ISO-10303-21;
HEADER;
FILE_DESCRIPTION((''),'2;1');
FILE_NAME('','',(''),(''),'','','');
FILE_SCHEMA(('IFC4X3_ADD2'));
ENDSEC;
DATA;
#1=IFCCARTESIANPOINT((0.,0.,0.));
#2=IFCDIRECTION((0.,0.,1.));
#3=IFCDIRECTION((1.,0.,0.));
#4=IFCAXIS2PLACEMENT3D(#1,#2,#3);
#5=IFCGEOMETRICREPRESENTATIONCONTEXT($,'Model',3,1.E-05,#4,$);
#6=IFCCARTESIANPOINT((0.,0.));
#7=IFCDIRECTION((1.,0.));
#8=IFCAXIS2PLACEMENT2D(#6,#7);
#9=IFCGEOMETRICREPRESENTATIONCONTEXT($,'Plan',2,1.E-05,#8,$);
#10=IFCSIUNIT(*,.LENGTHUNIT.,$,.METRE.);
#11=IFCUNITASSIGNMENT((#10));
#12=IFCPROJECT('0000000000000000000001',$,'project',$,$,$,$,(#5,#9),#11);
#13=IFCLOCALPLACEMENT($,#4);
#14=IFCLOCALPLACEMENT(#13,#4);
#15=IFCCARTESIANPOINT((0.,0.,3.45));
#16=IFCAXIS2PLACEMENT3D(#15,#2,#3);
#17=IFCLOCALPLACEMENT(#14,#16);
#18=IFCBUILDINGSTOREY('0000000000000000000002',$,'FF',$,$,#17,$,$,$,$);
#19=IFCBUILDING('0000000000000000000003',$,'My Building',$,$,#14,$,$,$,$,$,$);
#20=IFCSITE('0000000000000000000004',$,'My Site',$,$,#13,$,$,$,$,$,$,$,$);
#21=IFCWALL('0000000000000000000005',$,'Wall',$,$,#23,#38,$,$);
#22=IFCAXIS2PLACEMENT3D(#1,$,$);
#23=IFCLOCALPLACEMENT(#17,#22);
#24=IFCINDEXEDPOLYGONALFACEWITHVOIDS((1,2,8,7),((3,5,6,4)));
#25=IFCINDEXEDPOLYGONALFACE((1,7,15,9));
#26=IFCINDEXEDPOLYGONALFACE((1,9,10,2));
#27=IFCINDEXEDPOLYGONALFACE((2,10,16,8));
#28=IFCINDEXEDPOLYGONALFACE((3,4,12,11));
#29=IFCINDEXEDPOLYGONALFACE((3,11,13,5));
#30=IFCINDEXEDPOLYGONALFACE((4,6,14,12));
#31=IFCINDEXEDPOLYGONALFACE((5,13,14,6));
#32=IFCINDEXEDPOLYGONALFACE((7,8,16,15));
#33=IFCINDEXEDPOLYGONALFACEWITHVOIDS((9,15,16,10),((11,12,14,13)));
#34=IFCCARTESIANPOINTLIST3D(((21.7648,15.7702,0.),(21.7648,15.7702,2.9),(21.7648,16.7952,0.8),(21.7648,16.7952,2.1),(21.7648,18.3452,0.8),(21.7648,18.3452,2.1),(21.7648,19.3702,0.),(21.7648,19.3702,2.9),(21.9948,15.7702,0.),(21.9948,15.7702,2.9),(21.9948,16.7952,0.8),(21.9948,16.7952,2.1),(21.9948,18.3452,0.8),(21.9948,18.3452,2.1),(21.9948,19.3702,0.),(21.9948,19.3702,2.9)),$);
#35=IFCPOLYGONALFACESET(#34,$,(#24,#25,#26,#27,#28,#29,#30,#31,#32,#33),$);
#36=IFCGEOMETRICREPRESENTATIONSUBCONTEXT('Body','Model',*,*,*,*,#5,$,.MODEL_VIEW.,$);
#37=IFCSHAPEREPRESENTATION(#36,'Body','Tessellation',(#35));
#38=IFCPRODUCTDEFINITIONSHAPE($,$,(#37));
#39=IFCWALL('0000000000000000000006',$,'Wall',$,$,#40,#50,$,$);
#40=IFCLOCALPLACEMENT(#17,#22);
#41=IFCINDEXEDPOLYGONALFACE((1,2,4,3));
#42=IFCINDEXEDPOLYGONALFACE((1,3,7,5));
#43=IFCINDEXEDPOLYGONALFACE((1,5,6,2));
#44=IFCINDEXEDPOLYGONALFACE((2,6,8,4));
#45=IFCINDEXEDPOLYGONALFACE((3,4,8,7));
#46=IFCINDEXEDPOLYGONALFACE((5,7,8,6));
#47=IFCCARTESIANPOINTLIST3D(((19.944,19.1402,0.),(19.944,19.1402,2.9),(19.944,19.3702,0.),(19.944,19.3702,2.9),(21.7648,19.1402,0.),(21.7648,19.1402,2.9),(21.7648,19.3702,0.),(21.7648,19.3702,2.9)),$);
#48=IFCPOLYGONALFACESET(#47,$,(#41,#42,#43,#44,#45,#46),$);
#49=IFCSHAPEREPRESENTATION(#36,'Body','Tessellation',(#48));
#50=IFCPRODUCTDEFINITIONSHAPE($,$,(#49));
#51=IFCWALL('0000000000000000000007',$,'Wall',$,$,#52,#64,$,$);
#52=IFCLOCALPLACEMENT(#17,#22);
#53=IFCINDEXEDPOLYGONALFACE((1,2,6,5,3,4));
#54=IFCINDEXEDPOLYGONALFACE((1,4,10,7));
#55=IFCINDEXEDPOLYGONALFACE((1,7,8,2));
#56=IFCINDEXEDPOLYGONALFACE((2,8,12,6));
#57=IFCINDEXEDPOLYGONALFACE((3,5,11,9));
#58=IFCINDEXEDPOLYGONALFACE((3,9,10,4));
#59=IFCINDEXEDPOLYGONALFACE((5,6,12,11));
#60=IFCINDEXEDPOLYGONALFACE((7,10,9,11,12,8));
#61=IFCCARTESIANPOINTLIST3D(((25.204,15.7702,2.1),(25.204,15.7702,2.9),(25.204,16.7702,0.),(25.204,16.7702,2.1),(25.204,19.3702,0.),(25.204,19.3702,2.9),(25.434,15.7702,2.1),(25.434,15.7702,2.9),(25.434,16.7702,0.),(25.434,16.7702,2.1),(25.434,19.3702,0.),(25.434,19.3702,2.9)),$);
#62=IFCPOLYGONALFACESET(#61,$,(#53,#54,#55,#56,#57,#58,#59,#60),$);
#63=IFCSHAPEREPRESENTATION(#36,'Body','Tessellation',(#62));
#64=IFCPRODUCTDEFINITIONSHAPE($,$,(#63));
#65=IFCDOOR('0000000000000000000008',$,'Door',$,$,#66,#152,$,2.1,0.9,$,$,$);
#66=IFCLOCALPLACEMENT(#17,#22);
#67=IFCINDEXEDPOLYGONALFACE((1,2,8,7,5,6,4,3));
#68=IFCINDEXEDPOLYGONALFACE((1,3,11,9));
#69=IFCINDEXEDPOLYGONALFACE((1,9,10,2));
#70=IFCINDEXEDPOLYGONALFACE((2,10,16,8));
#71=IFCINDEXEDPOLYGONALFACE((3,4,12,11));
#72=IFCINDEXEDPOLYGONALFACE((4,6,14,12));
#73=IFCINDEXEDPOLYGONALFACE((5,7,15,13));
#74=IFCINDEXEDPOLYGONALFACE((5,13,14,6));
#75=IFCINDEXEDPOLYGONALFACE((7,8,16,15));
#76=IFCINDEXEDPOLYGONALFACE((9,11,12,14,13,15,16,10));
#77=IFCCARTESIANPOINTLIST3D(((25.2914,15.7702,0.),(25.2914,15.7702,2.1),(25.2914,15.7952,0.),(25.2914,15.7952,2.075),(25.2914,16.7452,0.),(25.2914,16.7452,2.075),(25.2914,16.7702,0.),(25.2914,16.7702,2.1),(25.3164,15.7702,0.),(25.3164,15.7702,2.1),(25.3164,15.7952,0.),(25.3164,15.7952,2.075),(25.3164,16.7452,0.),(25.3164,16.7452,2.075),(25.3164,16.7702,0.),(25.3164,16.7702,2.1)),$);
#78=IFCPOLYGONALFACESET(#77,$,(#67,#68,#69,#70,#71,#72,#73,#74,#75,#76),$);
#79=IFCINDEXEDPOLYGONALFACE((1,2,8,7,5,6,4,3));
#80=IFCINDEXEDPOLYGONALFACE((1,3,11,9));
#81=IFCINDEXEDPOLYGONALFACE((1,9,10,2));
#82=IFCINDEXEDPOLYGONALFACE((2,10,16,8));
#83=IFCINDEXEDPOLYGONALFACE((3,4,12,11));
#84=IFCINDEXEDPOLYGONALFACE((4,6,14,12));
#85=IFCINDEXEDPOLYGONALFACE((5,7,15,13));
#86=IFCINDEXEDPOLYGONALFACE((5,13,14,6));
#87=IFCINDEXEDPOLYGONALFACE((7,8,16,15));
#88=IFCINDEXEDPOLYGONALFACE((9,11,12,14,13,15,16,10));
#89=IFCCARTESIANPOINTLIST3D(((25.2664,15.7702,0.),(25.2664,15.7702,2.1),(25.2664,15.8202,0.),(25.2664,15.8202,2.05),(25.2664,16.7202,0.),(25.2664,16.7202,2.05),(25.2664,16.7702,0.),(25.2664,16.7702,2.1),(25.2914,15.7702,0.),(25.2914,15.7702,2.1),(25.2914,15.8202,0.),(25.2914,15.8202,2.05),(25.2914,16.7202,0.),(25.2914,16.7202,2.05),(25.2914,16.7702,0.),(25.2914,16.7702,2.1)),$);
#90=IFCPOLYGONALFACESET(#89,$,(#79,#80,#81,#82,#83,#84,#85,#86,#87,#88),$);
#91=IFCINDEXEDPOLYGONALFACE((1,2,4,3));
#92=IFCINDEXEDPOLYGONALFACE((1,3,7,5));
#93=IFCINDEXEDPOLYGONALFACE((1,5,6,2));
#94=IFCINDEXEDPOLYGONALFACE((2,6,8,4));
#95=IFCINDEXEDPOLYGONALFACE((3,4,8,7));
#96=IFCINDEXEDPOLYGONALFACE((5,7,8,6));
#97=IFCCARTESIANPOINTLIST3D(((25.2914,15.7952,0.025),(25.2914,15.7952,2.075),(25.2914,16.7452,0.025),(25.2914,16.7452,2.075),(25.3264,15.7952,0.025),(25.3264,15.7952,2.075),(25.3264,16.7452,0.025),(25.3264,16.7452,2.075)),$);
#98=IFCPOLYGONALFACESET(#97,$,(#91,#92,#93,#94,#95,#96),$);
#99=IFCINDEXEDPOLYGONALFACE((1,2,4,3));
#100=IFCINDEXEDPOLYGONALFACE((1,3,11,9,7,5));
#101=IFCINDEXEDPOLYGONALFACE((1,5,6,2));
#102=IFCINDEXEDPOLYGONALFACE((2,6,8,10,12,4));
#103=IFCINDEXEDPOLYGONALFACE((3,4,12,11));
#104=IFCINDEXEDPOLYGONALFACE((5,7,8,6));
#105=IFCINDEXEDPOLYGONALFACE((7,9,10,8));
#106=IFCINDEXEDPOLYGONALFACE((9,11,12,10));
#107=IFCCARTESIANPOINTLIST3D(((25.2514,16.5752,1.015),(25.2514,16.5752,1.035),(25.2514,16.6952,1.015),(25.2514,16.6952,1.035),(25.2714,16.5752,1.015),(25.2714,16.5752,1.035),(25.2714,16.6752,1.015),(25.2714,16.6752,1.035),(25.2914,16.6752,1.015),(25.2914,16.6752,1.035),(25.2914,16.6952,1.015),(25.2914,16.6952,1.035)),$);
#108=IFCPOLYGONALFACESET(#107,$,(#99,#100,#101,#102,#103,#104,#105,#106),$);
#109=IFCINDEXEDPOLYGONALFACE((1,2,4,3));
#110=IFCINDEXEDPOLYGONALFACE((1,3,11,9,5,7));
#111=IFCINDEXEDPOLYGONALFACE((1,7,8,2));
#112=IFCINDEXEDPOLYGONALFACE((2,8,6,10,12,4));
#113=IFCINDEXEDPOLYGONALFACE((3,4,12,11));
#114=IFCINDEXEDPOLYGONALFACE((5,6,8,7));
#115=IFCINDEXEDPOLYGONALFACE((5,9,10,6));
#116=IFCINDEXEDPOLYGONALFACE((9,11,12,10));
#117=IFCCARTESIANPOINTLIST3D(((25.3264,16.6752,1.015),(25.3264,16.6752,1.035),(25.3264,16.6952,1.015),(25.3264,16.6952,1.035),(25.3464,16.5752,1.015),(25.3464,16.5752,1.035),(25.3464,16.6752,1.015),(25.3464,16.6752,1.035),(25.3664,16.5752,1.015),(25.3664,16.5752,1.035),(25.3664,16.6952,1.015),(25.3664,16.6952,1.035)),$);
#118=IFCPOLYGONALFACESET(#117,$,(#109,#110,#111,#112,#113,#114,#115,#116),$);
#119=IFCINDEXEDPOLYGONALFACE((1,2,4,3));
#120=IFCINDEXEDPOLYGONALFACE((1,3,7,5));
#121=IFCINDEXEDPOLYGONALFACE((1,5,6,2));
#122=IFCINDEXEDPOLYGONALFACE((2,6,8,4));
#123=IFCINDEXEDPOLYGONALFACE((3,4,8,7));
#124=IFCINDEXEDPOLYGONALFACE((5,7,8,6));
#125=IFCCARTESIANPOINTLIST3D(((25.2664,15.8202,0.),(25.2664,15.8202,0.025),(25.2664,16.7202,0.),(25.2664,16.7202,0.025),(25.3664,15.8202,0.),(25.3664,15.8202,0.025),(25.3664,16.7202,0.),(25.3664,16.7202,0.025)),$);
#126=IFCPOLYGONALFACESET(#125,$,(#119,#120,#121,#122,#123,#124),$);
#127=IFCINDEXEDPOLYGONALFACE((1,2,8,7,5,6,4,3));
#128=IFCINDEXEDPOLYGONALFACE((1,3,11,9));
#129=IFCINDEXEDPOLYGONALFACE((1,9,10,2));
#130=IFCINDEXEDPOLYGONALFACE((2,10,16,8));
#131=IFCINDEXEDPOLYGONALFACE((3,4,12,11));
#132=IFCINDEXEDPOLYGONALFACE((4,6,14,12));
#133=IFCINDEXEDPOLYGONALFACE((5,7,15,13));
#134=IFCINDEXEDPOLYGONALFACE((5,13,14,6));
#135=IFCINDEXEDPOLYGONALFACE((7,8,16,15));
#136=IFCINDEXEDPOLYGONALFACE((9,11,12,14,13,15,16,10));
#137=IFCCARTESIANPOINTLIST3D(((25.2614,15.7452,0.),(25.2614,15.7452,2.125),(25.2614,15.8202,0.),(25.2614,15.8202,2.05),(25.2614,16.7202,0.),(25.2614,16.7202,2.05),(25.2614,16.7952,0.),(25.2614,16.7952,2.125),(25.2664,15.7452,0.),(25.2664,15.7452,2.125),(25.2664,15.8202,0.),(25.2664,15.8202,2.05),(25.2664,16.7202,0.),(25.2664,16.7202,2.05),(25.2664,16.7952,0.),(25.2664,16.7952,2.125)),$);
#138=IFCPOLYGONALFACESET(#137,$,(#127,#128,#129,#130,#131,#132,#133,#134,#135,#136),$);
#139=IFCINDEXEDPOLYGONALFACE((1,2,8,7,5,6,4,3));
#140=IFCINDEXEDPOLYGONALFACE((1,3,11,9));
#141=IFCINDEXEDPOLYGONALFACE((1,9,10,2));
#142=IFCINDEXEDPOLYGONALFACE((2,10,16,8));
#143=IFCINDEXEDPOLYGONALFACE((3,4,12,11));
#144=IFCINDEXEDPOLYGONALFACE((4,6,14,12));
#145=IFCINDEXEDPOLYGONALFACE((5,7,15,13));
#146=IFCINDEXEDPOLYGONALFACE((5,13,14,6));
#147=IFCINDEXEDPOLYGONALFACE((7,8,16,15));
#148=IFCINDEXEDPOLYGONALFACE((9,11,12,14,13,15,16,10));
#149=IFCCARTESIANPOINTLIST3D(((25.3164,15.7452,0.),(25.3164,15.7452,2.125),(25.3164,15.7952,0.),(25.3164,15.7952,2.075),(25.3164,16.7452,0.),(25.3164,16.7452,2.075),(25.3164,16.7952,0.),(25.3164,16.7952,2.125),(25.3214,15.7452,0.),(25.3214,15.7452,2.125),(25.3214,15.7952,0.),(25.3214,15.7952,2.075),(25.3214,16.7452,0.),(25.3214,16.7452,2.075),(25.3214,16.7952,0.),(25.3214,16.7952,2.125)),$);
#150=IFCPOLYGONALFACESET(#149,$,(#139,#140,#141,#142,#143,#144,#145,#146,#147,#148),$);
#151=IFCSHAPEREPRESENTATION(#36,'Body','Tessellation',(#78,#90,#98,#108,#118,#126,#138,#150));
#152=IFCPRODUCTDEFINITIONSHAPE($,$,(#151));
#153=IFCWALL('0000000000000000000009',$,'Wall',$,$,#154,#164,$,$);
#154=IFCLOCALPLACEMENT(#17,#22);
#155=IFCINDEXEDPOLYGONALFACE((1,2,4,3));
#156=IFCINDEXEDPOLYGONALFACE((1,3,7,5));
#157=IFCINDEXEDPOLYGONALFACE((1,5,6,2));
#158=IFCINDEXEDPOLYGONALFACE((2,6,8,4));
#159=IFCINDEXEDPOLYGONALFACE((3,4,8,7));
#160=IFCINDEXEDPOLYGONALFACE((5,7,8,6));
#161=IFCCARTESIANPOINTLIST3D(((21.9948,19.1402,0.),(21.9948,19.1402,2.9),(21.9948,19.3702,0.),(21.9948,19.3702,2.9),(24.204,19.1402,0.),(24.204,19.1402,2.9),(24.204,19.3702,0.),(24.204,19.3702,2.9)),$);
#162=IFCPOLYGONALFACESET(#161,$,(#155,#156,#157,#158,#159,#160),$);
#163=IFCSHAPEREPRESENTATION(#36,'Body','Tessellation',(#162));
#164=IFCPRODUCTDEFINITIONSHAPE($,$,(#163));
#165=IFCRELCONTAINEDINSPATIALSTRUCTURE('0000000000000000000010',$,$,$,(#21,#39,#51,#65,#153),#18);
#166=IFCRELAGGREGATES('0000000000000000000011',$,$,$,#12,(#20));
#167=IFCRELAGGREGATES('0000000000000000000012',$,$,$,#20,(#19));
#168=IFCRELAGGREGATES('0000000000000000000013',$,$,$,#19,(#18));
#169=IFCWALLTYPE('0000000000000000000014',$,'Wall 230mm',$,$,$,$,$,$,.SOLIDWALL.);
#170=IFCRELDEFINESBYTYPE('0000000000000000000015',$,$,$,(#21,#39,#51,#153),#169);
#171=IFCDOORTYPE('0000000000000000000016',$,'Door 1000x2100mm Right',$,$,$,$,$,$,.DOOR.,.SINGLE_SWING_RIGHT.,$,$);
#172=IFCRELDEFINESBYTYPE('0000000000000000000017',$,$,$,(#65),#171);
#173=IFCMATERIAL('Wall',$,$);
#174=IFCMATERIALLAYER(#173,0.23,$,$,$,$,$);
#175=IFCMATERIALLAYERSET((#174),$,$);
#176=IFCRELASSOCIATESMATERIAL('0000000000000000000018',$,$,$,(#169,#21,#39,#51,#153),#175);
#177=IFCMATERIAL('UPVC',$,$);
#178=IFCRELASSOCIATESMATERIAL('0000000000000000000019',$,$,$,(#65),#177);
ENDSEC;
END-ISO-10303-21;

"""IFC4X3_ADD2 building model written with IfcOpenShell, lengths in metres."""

from ifc_helpers import new_model, entity, si_unit, frame, origin_with_axes, origin_2d_with_axis, place, context, subcontext, project, spatial, line, indexed_curve, outline, extrude, shape, source, transform, mapped, material, layer, layer_set, layer_usage, type_object, type_shapes, element, fill, save


model = new_model("IFC4X3_ADD2")

# Units and contexts
model_context = context("Model", 3, precision=1e-05, world=origin_with_axes())
plan_context = context("Plan", 2, precision=1e-05, world=origin_2d_with_axis())
body_context_1 = subcontext(model_context, "Body", "Model", "MODEL_VIEW")
body_context_2 = subcontext(plan_context, "Body", "Plan", "PLAN_VIEW")
ifc_project = project(units=[si_unit("LENGTHUNIT", "METRE")], contexts=[model_context, plan_context])

# Site, building, storey
site_placement = place(None, origin_with_axes())
site = spatial("IfcSite", under=ifc_project, at=site_placement, Name="My Site")
building_placement = place(site_placement, origin_with_axes())
building = spatial("IfcBuilding", under=site, at=building_placement, Name="My Building")
storey_placement = place(building_placement, frame((0.0, 0.0, 3.45), z_axis=(0.0, 0.0, 1.0), x_axis=(1.0, 0.0, 0.0)))
storey = spatial("IfcBuildingStorey", under=building, at=storey_placement, Name="FF")

# Shared definitions
ifc_material_1 = material(Name="Wall")
ifc_material_2 = material(Name="UPVC")

# Shared definitions
ifc_layer_1 = layer(ifc_material_1, 0.23)
ifc_layer_set_1 = layer_set([ifc_layer_1])
wall_type_1 = type_object("IfcWallType", Name="Wall 230mm", PredefinedType="SOLIDWALL", material=ifc_layer_set_1)

# Wall, opening
ifc_layer_usage_1 = layer_usage(ifc_layer_set_1, "AXIS2", "POSITIVE", 0.0)
wall_1_placement = place(storey_placement, frame((21.9948, 15.7702, 0.0), z_axis=(0.0, 0.0, 1.0), x_axis=(0.000001, 1.0, 0.0)))
wall_1 = element("IfcWall", 1, at=wall_1_placement, inside=storey, type_object=wall_type_1, material=ifc_layer_usage_1, Name="Wall", context=body_context_1, shape_type="SweptSolid", body=[
    extrude(outline(indexed_curve([(0.0, 0.0), (0.0, 0.23), (3.6, 0.23), (3.6, 0.0), (0.0, 0.0)], self_intersect=False)), origin_with_axes(), (0.0, 0.0, 1.0), 2.9),
])
shared_shape_1 = source(origin_with_axes(), body_context_1, "Body", "SweptSolid", [
    extrude(outline(indexed_curve([(0.0, 0.0), (1.55, 0.0), (1.55, 1.3), (0.0, 1.3)], segments=[line(1, 2, 3, 4, 1)])), frame((-0.775, -0.6, 0.0), z_axis=(0.0, -1.0, 0.0), x_axis=(1.0, 0.0, 0.0)), (0.0, 0.0, -1.0), 1.2),
])
opening_1_placement = place(wall_1_placement, frame((1.8, 0.0, 0.8), z_axis=(0.0, 0.0, 1.0), x_axis=(1.0, 0.0, 0.0)))
element("IfcOpeningElement", 2, at=opening_1_placement, cuts=wall_1, PredefinedType="OPENING", context=body_context_1, shape_type="MappedRepresentation", body=[
    mapped(shared_shape_1, transform((0.0, 0.0, 0.0), x_axis=(1.0, 0.0, 0.0), y_axis=(0.0, 1.0, 0.0), z_axis=(0.0, 0.0, 1.0), scale=1.0)),
])

# Wall
ifc_layer_usage_2 = layer_usage(ifc_layer_set_1, "AXIS2", "POSITIVE", 0.0)
wall_2_placement = place(storey_placement, frame((21.7648, 19.3702, 0.0), z_axis=(0.0, 0.0, 1.0), x_axis=(-1.0, 0.0, 0.0)))
element("IfcWall", 3, at=wall_2_placement, inside=storey, type_object=wall_type_1, material=ifc_layer_usage_2, Name="Wall", context=body_context_1, shape_type="SweptSolid", body=[
    extrude(outline(indexed_curve([(0.0, 0.0), (0.0, 0.23), (1.8208, 0.23), (1.8208, 0.0), (0.0, 0.0)], self_intersect=False)), origin_with_axes(), (0.0, 0.0, 1.0), 2.9),
])

# Wall, opening, door
ifc_layer_usage_3 = layer_usage(ifc_layer_set_1, "AXIS2", "POSITIVE", 0.0)
wall_3_placement = place(storey_placement, frame((25.434, 15.7702, 0.0), z_axis=(0.0, 0.0, 1.0), x_axis=(0.000001, 1.0, 0.0)))
wall_3 = element("IfcWall", 4, at=wall_3_placement, inside=storey, type_object=wall_type_1, material=ifc_layer_usage_3, Name="Wall", context=body_context_1, shape_type="SweptSolid", body=[
    extrude(outline(indexed_curve([(0.0, 0.0), (0.0, 0.23), (3.6, 0.23), (3.6, 0.0), (0.0, 0.0)], self_intersect=False)), origin_with_axes(), (0.0, 0.0, 1.0), 2.9),
])
shared_shape_2 = source(origin_with_axes(), body_context_1, "Body", "SweptSolid", [
    extrude(outline(indexed_curve([(0.0, 0.0), (1.0, 0.0), (1.0, 2.1), (0.0, 2.1)], segments=[line(1, 2, 3, 4, 1)])), frame((0.0, -0.6, 0.0), z_axis=(0.0, -1.0, 0.0), x_axis=(1.0, 0.0, 0.0)), (0.0, 0.0, -1.0), 1.2),
])
opening_2_placement = place(wall_3_placement, frame((1.0, 0.1676, 0.0), z_axis=(0.0, 0.0, 1.0), x_axis=(-1.0, 0.0, 0.0)))
opening_2 = element("IfcOpeningElement", 5, at=opening_2_placement, cuts=wall_3, PredefinedType="OPENING", context=body_context_1, shape_type="MappedRepresentation", body=[
    mapped(shared_shape_2, transform((0.0, 0.0, 0.0), x_axis=(1.0, 0.0, 0.0), y_axis=(0.0, 1.0, 0.0), z_axis=(0.0, 0.0, 1.0), scale=1.0)),
])
door_type_1 = type_object("IfcDoorType", Name="Door 1000x2100mm Right", OperationType="SINGLE_SWING_RIGHT", PredefinedType="DOOR")
shared_shape_3 = source(origin_with_axes(), body_context_1, "Body", "SweptSolid", [
    extrude(outline(indexed_curve([(0.0, 0.0), (0.0, 2.1), (1.0, 2.1), (1.0, 0.0), (0.975, 0.0), (0.975, 2.075), (0.025, 2.075), (0.025, 0.0)], segments=[line(1, 2, 3, 4, 5, 6, 7, 8, 1)])), frame((0.0, 0.025, 0.0), z_axis=(0.0, -1.0, 0.0), x_axis=(1.0, 0.0, 0.0)), (0.0, 0.0, -1.0), 0.025),
    extrude(outline(indexed_curve([(0.0, 0.0), (0.0, 2.1), (1.0, 2.1), (1.0, 0.0), (0.95, 0.0), (0.95, 2.05), (0.05, 2.05), (0.05, 0.0)], segments=[line(1, 2, 3, 4, 5, 6, 7, 8, 1)])), frame((0.0, 0.0, 0.0), z_axis=(0.0, -1.0, 0.0), x_axis=(1.0, 0.0, 0.0)), (0.0, 0.0, -1.0), 0.025),
    extrude(outline(indexed_curve([(0.0, 0.0), (0.95, 0.0), (0.95, 0.035), (0.0, 0.035)], segments=[line(1, 2, 3, 4, 1)])), frame((0.025, 0.025, 0.025), z_axis=(0.0, 0.0, 1.0), x_axis=(1.0, 0.0, 0.0)), (0.0, 0.0, 1.0), 2.05),
    extrude(outline(indexed_curve([(0.0, 0.0), (0.0, -0.04), (0.12, -0.04), (0.12, -0.02), (0.02, -0.02), (0.02, 0.0)], segments=[line(1, 2, 3, 4, 5, 6, 1)])), frame((0.075, 0.025, 1.015), z_axis=(0.0, 0.0, 1.0), x_axis=(1.0, 0.0, 0.0)), (0.0, 0.0, 1.0), 0.02),
    extrude(outline(indexed_curve([(0.0, 0.0), (0.0, 0.04), (0.12, 0.04), (0.12, 0.02), (0.02, 0.02), (0.02, 0.0)], segments=[line(1, 2, 3, 4, 5, 6, 1)])), frame((0.075, 0.06, 1.015), z_axis=(0.0, 0.0, 1.0), x_axis=(1.0, 0.0, 0.0)), (0.0, 0.0, 1.0), 0.02),
    extrude(outline(indexed_curve([(0.0, 0.0), (0.9, 0.0), (0.9, 0.1), (0.0, 0.1)], segments=[line(1, 2, 3, 4, 1)])), frame((0.05, 0.0, 0.0), z_axis=(0.0, 0.0, 1.0), x_axis=(1.0, 0.0, 0.0)), (0.0, 0.0, 1.0), 0.025),
    extrude(outline(indexed_curve([(0.0, 0.0), (0.0, 2.125), (1.05, 2.125), (1.05, 0.0), (0.975, 0.0), (0.975, 2.05), (0.075, 2.05), (0.075, 0.0)], segments=[line(1, 2, 3, 4, 5, 6, 7, 8, 1)])), frame((-0.025, -0.005, 0.0), z_axis=(0.0, -1.0, 0.0), x_axis=(1.0, 0.0, 0.0)), (0.0, 0.0, -1.0), 0.005),
    extrude(outline(indexed_curve([(0.0, 0.0), (0.0, 2.125), (1.05, 2.125), (1.05, 0.0), (1.0, 0.0), (1.0, 2.075), (0.05, 2.075), (0.05, 0.0)], segments=[line(1, 2, 3, 4, 5, 6, 7, 8, 1)])), frame((-0.025, 0.05, 0.0), z_axis=(0.0, -1.0, 0.0), x_axis=(1.0, 0.0, 0.0)), (0.0, 0.0, -1.0), 0.005),
])
shared_shape_4 = source(origin_with_axes(), body_context_2, "Body", "Curve2D", [
    entity("IfcIndexedPolyCurve", entity("IfcCartesianPointList2D", [[0.0, 0.0], [0.0, 0.05], [0.025, 0.05], [0.025, 0.025], [0.05, 0.025], [0.05, 0.0]]), [entity("IfcLineIndex", [1, 2, 3, 4, 5, 6, 1])]),
    entity("IfcIndexedPolyCurve", entity("IfcCartesianPointList2D", [[1.0, 0.0], [1.0, 0.05], [0.975, 0.05], [0.975, 0.025], [0.95, 0.025], [0.95, 0.0]]), [entity("IfcLineIndex", [1, 2, 3, 4, 5, 6, 1])]),
    entity("IfcTrimmedCurve", entity("IfcEllipse", entity("IfcAxis2Placement2D", entity("IfcCartesianPoint", [0.94, 0.05]), entity("IfcDirection", [1.0, 0.0])), 0.915, 0.95), [entity("IfcCartesianPoint", [0.94, 1.0])], [entity("IfcCartesianPoint", [0.025, 0.05])], True, "CARTESIAN"),
    entity("IfcIndexedPolyCurve", entity("IfcCartesianPointList2D", [[0.975, 0.05], [0.94, 0.05], [0.94, 1.0], [0.975, 1.0]]), [entity("IfcLineIndex", [1, 2, 3, 4, 1])]),
])
type_shapes(door_type_1, [shared_shape_3, shared_shape_4])
door_1_placement = place(opening_2_placement, origin_with_axes())
door_1 = element("IfcDoor", 6, at=door_1_placement, inside=storey, type_object=door_type_1, material=ifc_material_2, Name="Door", OverallHeight=2.1, OverallWidth=0.9, shapes=[
    shape(body_context_1, "Body", "MappedRepresentation", [mapped(shared_shape_3, transform((0.0, 0.0, 0.0), x_axis=(1.0, 0.0, 0.0), y_axis=(0.0, 1.0, 0.0), z_axis=(0.0, 0.0, 1.0), scale=1.0))]),
    shape(body_context_2, "Body", "MappedRepresentation", [mapped(shared_shape_4, transform((0.0, 0.0, 0.0), x_axis=(1.0, 0.0, 0.0), y_axis=(0.0, 1.0, 0.0), z_axis=(0.0, 0.0, 1.0), scale=1.0))]),
])
fill(opening_2, door_1)

# Wall
ifc_layer_usage_4 = layer_usage(ifc_layer_set_1, "AXIS2", "POSITIVE", 0.0)
wall_4_placement = place(storey_placement, frame((24.204, 19.3702, 0.0), z_axis=(0.0, 0.0, 1.0), x_axis=(-1.0, 0.0, 0.0)))
element("IfcWall", 7, at=wall_4_placement, inside=storey, type_object=wall_type_1, material=ifc_layer_usage_4, Name="Wall", context=body_context_1, shape_type="SweptSolid", body=[
    extrude(outline(indexed_curve([(0.0, 0.0), (0.0, 0.23), (2.2092, 0.23), (2.2092, 0.0), (0.0, 0.0)], self_intersect=False)), origin_with_axes(), (0.0, 0.0, 1.0), 2.9),
])

save(model, "model.ifc")
